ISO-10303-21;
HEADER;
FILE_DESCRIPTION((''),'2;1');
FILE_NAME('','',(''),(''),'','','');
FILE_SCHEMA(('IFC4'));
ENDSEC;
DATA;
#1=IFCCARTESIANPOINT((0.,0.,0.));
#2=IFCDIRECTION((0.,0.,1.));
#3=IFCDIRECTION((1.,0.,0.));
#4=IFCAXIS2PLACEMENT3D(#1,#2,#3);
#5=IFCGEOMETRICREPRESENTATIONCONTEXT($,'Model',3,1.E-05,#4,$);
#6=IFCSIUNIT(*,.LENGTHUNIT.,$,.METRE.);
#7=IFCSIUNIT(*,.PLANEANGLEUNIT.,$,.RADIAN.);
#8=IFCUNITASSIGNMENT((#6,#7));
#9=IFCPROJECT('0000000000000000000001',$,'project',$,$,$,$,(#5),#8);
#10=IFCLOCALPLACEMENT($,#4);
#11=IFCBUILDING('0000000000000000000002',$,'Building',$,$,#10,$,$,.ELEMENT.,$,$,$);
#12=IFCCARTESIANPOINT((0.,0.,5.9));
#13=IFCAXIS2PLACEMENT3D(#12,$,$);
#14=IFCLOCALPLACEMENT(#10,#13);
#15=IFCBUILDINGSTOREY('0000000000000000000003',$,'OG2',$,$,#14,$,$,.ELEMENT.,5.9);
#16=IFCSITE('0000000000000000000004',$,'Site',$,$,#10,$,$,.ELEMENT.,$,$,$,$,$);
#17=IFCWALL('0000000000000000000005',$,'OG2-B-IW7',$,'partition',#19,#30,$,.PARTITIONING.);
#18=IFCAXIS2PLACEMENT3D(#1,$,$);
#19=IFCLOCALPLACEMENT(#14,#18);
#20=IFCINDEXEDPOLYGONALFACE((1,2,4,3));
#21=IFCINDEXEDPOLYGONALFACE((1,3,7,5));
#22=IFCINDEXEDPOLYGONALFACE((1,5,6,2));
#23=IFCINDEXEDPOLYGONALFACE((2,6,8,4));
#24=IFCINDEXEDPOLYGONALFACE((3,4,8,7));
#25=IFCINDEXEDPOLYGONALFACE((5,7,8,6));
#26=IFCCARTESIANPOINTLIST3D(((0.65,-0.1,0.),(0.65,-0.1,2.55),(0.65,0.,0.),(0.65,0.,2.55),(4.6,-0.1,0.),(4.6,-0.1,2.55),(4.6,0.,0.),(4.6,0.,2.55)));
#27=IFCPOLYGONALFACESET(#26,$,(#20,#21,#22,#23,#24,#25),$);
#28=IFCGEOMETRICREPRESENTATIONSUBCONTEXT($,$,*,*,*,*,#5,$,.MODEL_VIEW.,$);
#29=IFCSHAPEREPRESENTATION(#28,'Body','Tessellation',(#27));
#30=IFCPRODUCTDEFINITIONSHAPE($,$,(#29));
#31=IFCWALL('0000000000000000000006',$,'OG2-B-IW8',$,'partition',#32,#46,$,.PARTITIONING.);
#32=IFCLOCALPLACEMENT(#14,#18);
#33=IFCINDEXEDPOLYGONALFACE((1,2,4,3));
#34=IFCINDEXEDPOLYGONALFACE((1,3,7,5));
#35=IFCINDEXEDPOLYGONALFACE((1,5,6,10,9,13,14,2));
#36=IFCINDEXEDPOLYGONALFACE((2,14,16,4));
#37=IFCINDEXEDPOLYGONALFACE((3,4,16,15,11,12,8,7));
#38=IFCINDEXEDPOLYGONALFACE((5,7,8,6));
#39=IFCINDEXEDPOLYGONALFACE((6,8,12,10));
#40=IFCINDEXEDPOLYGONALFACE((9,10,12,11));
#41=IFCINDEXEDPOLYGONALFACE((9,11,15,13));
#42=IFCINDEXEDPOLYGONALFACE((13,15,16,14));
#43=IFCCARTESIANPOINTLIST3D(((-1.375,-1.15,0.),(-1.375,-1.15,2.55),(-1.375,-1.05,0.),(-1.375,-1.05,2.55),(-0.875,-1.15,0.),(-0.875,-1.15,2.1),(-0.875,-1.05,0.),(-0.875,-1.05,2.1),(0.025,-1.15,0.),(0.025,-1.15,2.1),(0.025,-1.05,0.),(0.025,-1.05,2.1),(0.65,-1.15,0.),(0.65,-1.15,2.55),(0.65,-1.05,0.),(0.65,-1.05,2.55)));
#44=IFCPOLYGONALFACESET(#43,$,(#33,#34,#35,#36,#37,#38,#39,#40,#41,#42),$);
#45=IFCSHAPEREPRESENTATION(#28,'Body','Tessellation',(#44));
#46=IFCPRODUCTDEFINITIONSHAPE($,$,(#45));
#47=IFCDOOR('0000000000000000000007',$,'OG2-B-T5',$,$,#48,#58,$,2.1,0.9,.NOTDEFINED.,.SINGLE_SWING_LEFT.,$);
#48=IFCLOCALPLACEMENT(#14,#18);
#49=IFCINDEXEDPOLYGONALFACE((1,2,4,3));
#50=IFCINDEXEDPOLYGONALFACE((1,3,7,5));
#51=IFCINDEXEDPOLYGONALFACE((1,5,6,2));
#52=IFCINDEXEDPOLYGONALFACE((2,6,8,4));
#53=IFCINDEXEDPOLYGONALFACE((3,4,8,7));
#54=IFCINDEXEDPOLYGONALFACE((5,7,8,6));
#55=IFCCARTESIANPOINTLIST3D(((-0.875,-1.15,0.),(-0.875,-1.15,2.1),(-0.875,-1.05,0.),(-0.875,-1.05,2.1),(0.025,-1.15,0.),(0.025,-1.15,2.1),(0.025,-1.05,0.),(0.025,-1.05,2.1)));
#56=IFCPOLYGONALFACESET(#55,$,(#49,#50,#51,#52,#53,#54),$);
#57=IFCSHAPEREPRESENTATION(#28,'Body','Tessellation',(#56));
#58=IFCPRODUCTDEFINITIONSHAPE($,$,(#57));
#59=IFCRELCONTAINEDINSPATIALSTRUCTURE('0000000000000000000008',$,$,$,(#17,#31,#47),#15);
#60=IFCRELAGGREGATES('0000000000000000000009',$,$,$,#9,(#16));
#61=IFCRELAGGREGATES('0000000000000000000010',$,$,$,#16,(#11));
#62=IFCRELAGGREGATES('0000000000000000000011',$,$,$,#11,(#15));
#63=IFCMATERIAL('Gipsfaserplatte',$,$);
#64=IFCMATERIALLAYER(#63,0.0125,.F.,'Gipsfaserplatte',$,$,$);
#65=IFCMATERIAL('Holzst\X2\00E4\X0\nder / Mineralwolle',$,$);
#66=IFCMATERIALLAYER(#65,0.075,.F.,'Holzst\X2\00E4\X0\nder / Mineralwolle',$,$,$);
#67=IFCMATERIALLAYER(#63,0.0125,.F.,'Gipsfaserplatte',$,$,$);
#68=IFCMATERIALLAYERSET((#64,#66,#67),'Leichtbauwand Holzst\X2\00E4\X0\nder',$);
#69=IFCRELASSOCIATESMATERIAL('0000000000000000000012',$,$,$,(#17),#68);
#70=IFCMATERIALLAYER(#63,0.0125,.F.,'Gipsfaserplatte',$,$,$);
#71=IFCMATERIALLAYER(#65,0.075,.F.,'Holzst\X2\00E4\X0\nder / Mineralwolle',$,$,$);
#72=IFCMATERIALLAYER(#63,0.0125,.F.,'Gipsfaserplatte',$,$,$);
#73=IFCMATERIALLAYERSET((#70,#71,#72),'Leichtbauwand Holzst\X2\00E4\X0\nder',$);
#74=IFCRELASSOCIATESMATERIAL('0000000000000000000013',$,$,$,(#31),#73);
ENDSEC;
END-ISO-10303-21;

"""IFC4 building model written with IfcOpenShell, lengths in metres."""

from ifc_helpers import new_model, si_unit, frame, frame_2d, origin, origin_with_axes, place, context, subcontext, project, spatial, rectangle, extrude, material, layer, layer_set, element, fill, save


model = new_model("IFC4")

# Units and contexts
model_context = context("Model", 3, precision=1e-05, world=origin_with_axes())
sub_context = subcontext(model_context, None, None, "MODEL_VIEW")
ifc_project = project(units=[si_unit("LENGTHUNIT", "METRE"), si_unit("PLANEANGLEUNIT", "RADIAN")], contexts=[model_context])

# Site, building, storey
placement = place(None, origin_with_axes())
site = spatial("IfcSite", under=ifc_project, at=placement, Name="Site", CompositionType="ELEMENT")
building = spatial("IfcBuilding", under=site, at=placement, Name="Building", CompositionType="ELEMENT")
storey_placement = place(placement, frame((0.0, 0.0, 5.9)))
storey = spatial("IfcBuildingStorey", under=building, at=storey_placement, Name="OG2", CompositionType="ELEMENT", Elevation=5.9)

# Shared definitions
ifc_material_1 = material(Name="Gipsfaserplatte")

# Wall
ifc_material_2 = material(Name="Holzständer / Mineralwolle")
ifc_layer_1 = layer(ifc_material_1, 0.0125, ventilated=False, Name="Gipsfaserplatte")
ifc_layer_2 = layer(ifc_material_2, 0.075, ventilated=False, Name="Holzständer / Mineralwolle")
ifc_layer_3 = layer(ifc_material_1, 0.0125, ventilated=False, Name="Gipsfaserplatte")
ifc_layer_set_1 = layer_set([ifc_layer_1, ifc_layer_2, ifc_layer_3], Name="Leichtbauwand Holzständer")
wall_1_placement = place(storey_placement, frame((0.65, -0.05, 0.0), z_axis=(0.0, 0.0, 1.0), x_axis=(1.0, 0.0, 0.0)))
element("IfcWall", 1, at=wall_1_placement, inside=storey, material=ifc_layer_set_1, Name="OG2-B-IW7", ObjectType="partition", PredefinedType="PARTITIONING", context=sub_context, shape_type="SweptSolid", body=[
    extrude(rectangle(XDim=3.95, YDim=0.1, at=frame_2d((1.975, 0.0))), origin(), (0.0, 0.0, 1.0), 2.55),
])

# Wall, opening, door
ifc_layer_4 = layer(ifc_material_1, 0.0125, ventilated=False, Name="Gipsfaserplatte")
ifc_layer_5 = layer(ifc_material_2, 0.075, ventilated=False, Name="Holzständer / Mineralwolle")
ifc_layer_6 = layer(ifc_material_1, 0.0125, ventilated=False, Name="Gipsfaserplatte")
ifc_layer_set_2 = layer_set([ifc_layer_4, ifc_layer_5, ifc_layer_6], Name="Leichtbauwand Holzständer")
wall_2_placement = place(storey_placement, frame((-1.375, -1.1, 0.0), z_axis=(0.0, 0.0, 1.0), x_axis=(1.0, 0.0, 0.0)))
wall_2 = element("IfcWall", 2, at=wall_2_placement, inside=storey, material=ifc_layer_set_2, Name="OG2-B-IW8", ObjectType="partition", PredefinedType="PARTITIONING", context=sub_context, shape_type="SweptSolid", body=[
    extrude(rectangle(XDim=2.025, YDim=0.1, at=frame_2d((1.0125, 0.0))), origin(), (0.0, 0.0, 1.0), 2.55),
])
opening_1_placement = place(wall_2_placement, frame((0.95, 0.1, 0.0), z_axis=(0.0, -1.0, 0.0), x_axis=(1.0, 0.0, 0.0)))
opening_1 = element("IfcOpeningElement", 3, at=opening_1_placement, cuts=wall_2, PredefinedType="OPENING", context=sub_context, shape_type="SweptSolid", body=[
    extrude(rectangle(XDim=0.9, YDim=2.1, at=frame_2d((0.0, 1.05))), origin(), (0.0, 0.0, 1.0), 0.2),
])
door_1_placement = place(wall_2_placement, frame((0.95, 0.05, 0.0), z_axis=(0.0, -1.0, 0.0), x_axis=(1.0, 0.0, 0.0)))
door_1 = element("IfcDoor", 4, at=door_1_placement, inside=storey, Name="OG2-B-T5", OperationType="SINGLE_SWING_LEFT", OverallHeight=2.1, OverallWidth=0.9, PredefinedType="NOTDEFINED", context=sub_context, shape_type="SweptSolid", body=[
    extrude(rectangle(XDim=0.9, YDim=2.1, at=frame_2d((0.0, 1.05))), origin(), (0.0, 0.0, 1.0), 0.1),
])
fill(opening_1, door_1)

save(model, "model.ifc")
